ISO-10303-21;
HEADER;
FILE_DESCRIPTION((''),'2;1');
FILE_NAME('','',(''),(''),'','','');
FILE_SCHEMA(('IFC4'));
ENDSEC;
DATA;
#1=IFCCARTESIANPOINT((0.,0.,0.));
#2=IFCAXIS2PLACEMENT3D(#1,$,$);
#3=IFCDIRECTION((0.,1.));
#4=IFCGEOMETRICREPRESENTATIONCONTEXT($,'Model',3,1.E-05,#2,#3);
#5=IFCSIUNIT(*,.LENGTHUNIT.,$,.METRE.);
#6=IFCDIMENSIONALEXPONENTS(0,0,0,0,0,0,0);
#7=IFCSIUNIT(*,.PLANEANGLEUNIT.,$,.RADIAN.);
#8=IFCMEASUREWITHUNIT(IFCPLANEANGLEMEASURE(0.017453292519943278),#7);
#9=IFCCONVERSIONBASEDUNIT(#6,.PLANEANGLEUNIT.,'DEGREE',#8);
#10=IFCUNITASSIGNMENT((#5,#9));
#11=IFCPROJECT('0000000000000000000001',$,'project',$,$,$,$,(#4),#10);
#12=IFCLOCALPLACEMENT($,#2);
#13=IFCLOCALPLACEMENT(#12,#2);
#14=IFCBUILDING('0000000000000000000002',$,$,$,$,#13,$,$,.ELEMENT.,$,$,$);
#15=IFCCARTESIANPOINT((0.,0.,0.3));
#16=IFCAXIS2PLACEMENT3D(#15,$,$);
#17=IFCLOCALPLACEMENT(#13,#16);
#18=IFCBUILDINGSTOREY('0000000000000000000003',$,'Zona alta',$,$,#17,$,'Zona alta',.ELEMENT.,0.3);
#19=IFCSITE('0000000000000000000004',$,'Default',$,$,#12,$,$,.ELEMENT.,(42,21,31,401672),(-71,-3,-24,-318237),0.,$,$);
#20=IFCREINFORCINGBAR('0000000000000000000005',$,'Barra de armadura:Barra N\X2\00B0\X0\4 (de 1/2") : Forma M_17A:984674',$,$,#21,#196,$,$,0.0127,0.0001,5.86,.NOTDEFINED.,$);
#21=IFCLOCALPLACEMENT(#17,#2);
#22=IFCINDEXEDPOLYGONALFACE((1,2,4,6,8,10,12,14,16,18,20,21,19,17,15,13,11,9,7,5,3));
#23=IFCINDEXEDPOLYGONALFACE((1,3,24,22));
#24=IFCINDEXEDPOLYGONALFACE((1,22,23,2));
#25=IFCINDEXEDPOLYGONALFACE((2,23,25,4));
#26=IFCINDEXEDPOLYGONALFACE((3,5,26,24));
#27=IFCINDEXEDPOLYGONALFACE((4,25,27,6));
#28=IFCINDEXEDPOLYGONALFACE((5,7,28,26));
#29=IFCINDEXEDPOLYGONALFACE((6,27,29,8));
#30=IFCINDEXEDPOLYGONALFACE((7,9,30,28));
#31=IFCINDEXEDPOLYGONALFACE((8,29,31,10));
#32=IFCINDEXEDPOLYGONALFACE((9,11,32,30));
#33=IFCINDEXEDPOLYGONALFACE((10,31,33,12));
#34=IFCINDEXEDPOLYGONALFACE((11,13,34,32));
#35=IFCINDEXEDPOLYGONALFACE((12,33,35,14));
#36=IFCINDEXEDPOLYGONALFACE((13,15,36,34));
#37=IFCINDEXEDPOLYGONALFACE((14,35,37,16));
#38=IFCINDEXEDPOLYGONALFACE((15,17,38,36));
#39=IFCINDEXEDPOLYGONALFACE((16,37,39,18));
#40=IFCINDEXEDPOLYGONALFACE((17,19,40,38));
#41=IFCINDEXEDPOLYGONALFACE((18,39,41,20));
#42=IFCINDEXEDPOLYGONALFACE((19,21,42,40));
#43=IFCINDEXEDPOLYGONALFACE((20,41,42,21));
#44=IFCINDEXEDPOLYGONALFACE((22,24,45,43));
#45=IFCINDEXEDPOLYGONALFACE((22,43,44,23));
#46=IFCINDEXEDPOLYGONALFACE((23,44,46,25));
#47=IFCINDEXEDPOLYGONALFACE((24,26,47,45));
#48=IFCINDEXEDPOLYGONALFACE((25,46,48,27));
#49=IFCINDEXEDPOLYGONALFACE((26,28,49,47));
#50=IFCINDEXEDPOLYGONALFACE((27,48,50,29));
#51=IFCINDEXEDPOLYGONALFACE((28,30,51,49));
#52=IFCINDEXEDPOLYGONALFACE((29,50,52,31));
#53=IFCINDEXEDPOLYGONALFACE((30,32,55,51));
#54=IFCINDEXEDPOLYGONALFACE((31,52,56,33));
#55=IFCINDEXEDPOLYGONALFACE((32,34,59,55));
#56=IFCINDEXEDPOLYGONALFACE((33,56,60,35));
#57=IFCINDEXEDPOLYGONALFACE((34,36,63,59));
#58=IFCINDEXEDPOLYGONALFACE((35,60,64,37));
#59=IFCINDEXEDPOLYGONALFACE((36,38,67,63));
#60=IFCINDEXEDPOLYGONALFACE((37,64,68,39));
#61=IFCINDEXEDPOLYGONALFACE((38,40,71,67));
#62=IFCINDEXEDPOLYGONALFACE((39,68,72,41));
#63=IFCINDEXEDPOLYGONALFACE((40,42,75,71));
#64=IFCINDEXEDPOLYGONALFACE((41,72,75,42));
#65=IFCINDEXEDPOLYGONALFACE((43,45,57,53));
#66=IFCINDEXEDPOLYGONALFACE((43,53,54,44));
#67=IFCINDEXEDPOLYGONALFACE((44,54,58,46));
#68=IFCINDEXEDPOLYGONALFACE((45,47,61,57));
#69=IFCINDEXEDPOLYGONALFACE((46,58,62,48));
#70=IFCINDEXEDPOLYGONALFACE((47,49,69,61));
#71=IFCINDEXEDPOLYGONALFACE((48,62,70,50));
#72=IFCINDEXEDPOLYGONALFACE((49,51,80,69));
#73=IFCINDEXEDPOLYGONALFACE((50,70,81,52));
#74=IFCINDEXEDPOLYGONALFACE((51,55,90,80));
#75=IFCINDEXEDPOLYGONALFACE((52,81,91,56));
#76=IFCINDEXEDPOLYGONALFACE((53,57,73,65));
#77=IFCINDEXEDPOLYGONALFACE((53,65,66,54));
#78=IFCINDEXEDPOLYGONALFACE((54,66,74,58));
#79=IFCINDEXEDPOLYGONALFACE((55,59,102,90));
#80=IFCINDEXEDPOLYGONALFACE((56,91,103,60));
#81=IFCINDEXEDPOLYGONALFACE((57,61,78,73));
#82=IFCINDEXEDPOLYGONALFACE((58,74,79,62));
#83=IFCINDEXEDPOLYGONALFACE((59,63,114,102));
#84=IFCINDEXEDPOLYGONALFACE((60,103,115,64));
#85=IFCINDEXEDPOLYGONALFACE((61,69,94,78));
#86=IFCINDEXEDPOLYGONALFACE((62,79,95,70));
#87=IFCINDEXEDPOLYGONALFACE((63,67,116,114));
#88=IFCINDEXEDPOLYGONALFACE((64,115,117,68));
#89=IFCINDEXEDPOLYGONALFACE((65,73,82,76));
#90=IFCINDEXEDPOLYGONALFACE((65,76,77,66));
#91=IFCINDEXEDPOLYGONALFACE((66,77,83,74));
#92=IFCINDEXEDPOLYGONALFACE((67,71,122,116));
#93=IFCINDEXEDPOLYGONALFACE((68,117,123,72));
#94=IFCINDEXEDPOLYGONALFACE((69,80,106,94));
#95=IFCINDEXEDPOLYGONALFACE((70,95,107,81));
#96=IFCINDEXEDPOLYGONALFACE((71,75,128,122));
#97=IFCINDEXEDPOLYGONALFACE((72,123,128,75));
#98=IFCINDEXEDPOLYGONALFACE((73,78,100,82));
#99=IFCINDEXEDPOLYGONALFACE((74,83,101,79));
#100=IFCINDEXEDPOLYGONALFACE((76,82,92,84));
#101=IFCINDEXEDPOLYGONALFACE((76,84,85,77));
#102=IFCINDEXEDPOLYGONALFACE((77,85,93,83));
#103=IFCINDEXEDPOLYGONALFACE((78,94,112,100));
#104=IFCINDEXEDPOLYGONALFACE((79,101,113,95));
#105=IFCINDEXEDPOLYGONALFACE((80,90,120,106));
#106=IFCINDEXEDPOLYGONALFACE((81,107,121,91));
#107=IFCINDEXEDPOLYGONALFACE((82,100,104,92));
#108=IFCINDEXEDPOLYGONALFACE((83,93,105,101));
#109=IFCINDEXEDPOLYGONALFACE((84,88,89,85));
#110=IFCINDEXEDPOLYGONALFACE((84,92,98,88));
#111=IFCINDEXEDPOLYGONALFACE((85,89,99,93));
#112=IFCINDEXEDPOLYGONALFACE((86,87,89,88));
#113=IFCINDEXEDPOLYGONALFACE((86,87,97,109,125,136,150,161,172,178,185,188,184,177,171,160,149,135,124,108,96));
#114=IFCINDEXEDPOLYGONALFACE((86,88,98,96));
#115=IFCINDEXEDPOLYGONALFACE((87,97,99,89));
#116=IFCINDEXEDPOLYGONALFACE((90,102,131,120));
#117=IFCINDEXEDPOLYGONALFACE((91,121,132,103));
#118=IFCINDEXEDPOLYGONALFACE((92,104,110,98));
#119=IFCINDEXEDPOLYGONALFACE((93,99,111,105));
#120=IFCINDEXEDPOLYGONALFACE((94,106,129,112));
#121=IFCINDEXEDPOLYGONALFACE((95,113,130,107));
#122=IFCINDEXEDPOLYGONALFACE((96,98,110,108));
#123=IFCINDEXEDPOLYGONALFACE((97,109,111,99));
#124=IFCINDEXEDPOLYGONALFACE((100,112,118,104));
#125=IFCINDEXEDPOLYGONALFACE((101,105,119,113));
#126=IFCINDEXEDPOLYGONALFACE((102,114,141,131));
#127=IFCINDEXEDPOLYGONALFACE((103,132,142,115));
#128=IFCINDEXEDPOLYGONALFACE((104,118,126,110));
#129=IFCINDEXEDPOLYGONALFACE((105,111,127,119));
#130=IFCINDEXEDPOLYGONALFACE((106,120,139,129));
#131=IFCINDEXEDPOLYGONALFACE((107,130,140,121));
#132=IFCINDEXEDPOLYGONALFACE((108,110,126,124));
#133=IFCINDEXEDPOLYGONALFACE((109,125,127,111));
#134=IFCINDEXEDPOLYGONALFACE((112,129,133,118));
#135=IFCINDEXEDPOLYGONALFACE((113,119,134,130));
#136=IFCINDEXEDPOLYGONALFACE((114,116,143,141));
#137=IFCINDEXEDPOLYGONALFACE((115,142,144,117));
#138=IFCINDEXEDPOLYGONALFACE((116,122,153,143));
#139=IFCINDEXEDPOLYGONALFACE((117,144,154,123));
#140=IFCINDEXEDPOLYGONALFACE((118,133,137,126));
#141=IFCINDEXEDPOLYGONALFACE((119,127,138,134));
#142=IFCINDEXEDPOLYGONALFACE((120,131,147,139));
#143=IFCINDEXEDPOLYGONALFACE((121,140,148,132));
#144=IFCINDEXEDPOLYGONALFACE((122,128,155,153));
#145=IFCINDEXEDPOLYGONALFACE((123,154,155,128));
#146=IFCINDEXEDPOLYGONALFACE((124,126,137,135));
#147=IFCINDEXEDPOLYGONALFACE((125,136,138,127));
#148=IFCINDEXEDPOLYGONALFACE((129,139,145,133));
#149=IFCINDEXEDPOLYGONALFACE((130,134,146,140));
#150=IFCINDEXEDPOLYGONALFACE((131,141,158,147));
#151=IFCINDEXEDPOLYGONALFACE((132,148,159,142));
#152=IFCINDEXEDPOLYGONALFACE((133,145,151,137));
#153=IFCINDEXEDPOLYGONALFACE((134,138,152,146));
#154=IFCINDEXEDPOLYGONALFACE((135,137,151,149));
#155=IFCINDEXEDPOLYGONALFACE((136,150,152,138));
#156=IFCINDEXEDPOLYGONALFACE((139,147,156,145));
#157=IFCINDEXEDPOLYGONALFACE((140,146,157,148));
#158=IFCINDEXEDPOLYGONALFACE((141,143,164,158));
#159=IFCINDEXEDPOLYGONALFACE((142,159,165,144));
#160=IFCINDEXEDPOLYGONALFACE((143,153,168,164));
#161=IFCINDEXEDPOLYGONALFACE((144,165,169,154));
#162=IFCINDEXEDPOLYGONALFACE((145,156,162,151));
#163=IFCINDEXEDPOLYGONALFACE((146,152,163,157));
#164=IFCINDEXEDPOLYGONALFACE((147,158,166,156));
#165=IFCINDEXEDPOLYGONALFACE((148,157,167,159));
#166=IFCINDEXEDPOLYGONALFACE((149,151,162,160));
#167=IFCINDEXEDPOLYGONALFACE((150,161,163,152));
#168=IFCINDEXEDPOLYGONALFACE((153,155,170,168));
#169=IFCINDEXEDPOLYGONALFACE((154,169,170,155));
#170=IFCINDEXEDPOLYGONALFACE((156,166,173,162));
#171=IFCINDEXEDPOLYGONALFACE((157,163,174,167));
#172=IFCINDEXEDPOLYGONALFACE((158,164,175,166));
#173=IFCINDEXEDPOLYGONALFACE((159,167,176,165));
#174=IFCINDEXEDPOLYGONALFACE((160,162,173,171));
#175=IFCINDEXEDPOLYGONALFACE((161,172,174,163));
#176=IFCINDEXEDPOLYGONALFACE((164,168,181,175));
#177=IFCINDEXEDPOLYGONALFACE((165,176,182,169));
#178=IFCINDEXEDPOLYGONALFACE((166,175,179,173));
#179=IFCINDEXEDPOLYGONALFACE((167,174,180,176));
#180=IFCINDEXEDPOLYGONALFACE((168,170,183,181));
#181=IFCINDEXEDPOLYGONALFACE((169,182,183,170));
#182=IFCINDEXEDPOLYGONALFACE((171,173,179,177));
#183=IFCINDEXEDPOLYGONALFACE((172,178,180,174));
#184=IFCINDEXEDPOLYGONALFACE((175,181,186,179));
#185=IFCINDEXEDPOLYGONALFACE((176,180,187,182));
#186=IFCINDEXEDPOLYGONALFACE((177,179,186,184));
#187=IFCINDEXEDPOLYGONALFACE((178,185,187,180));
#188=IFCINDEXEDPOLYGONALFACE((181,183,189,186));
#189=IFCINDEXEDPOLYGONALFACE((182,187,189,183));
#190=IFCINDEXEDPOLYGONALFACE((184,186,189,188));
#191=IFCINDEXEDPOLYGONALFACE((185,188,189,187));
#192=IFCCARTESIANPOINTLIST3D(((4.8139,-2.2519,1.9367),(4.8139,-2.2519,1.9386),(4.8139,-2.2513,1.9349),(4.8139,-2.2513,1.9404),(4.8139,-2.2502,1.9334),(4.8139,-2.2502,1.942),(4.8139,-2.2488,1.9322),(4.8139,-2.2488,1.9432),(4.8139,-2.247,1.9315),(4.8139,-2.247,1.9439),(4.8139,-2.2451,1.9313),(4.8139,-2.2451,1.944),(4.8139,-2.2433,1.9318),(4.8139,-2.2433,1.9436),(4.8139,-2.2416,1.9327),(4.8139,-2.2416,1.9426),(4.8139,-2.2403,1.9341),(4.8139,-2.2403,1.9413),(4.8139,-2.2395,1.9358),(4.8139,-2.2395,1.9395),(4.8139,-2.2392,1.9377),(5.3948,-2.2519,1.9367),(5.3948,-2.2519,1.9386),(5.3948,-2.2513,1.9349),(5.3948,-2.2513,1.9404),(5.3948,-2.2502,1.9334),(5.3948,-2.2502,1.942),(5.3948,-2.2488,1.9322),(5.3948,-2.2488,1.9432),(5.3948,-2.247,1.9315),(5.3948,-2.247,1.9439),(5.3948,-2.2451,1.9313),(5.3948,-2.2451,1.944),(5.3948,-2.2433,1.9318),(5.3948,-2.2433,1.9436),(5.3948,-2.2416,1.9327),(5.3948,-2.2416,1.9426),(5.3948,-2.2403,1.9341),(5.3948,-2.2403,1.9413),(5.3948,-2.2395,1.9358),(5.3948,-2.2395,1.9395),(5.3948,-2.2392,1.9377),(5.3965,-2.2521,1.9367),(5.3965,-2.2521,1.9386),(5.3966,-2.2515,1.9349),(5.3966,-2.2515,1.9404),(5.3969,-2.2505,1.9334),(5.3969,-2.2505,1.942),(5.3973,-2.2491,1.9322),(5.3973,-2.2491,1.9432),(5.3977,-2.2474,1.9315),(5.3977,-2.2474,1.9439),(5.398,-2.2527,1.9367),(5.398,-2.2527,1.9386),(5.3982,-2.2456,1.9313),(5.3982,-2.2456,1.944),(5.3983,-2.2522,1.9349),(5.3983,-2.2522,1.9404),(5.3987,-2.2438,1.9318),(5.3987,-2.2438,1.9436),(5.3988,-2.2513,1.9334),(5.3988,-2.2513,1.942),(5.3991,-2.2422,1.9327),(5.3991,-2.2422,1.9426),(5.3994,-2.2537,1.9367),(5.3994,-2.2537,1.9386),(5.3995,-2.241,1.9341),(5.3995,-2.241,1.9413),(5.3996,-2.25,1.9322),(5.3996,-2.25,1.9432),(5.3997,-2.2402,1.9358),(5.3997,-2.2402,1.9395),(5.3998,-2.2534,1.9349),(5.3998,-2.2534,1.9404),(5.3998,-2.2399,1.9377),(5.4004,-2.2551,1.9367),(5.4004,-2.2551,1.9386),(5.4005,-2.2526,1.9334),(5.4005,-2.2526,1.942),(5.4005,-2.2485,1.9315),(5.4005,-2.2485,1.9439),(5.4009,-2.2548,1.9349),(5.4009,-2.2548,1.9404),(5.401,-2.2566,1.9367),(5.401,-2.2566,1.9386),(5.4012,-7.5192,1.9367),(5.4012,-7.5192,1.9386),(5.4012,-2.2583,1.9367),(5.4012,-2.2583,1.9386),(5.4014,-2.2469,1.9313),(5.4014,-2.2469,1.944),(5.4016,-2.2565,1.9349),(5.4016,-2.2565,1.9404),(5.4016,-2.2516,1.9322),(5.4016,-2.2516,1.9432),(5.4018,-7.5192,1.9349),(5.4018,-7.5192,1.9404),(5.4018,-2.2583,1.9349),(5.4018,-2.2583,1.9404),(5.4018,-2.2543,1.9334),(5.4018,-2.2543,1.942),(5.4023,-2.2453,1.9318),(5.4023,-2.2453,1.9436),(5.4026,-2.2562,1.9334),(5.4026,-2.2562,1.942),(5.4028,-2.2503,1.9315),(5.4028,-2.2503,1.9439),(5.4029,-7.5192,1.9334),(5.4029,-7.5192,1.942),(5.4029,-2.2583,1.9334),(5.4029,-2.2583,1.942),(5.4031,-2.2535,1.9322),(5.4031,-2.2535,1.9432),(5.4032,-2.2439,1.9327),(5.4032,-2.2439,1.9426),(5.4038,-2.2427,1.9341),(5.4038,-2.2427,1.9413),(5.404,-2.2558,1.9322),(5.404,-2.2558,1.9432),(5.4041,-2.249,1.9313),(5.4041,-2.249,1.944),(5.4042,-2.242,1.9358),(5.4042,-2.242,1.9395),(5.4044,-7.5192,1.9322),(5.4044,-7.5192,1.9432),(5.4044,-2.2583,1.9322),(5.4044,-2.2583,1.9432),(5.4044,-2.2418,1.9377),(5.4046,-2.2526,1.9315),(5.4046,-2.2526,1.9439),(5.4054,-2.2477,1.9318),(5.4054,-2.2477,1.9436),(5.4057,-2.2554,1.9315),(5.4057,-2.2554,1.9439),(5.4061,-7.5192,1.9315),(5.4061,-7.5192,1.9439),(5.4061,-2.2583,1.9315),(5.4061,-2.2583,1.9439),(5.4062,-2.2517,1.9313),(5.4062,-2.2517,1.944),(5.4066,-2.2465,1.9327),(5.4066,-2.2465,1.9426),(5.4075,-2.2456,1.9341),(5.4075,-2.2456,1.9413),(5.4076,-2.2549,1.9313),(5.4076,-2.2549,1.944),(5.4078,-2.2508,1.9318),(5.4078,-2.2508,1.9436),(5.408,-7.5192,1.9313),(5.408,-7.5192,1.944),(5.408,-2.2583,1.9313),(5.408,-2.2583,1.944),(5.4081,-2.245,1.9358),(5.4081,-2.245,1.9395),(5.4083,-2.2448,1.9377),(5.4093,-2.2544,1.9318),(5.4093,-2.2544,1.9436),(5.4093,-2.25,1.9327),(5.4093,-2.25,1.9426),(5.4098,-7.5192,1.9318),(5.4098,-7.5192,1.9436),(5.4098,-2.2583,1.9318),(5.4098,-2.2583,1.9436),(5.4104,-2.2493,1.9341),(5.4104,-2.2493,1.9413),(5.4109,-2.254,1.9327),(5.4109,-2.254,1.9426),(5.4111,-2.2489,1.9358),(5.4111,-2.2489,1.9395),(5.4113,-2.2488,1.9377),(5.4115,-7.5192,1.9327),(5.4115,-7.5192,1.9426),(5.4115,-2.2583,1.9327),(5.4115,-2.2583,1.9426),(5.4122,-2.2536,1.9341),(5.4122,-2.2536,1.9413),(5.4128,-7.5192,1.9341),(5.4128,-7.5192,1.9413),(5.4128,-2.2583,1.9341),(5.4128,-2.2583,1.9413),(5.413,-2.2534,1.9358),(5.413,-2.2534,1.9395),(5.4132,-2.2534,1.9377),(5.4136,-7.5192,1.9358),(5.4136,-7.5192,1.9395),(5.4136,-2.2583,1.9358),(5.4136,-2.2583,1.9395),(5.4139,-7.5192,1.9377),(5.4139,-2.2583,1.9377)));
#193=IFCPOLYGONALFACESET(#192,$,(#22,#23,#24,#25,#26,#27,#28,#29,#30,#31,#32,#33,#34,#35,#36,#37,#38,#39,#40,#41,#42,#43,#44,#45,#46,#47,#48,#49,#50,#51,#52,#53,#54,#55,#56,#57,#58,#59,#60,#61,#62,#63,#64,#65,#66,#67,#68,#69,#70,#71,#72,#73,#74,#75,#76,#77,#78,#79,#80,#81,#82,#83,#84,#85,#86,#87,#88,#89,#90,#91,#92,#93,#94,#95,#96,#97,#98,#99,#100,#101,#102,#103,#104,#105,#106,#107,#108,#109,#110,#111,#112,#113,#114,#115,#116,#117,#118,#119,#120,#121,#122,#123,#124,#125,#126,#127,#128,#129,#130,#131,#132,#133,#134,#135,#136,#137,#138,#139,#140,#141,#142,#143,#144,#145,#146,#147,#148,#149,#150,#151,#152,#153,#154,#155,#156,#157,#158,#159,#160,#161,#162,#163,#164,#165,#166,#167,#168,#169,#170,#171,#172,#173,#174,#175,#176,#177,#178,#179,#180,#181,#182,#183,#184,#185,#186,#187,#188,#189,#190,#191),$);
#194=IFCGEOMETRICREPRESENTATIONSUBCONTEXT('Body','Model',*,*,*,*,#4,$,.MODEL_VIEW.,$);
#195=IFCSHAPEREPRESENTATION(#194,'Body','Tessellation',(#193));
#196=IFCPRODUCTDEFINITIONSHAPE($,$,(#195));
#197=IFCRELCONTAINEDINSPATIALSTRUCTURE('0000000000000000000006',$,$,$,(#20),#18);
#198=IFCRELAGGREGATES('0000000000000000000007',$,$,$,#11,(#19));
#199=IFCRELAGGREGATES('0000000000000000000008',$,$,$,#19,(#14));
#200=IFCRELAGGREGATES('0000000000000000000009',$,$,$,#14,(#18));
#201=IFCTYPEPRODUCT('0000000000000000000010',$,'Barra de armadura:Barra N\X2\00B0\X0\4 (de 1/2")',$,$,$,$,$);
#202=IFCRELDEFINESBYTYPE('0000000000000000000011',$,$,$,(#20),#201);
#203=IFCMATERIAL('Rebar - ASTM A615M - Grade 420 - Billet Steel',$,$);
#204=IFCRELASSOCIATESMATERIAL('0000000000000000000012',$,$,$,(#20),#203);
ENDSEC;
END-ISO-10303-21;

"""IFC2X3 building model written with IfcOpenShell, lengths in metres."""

from ifc_helpers import new_model, entity, si_unit, converted_unit, direction, frame, origin, place, context, subcontext, project, spatial, material, type_object, element, save


model = new_model("IFC2X3")

# Units and contexts
model_context = context("Model", 3, precision=1e-05, world=origin(), true_north=direction((0.0, 1.0)))
body_context = subcontext(model_context, "Body", "Model", "MODEL_VIEW")
ifc_project = project(units=[si_unit("LENGTHUNIT", "METRE"), converted_unit("PLANEANGLEUNIT", "DEGREE", entity("IfcPlaneAngleMeasure", 0.017453292519943278), si_unit("PLANEANGLEUNIT", "RADIAN"), dimensions=[0, 0, 0, 0, 0, 0, 0])], contexts=[model_context])

# Site, building, storey
site_placement = place(None, origin())
site = spatial("IfcSite", under=ifc_project, at=site_placement, Name="Default", CompositionType="ELEMENT", RefLatitude=(42, 21, 31, 401672), RefLongitude=(-71, -3, -24, -318237), RefElevation=0.0)
building_placement = place(site_placement, origin())
building = spatial("IfcBuilding", under=site, at=building_placement, CompositionType="ELEMENT")
storey_placement = place(building_placement, frame((0.0, 0.0, 0.3)))
storey = spatial("IfcBuildingStorey", under=building, at=storey_placement, Name="Zona alta", LongName="Zona alta", CompositionType="ELEMENT", Elevation=0.3)

# Reinforcing bar
ifc_material_1 = material(Name="Rebar - ASTM A615M - Grade 420 - Billet Steel")
type_product_1 = type_object("IfcTypeProduct", Name="Barra de armadura:Barra N°4 (de 1/2\")")
reinforcing_bar_1_placement = place(storey_placement, origin())
element("IfcReinforcingBar", 1, at=reinforcing_bar_1_placement, inside=storey, type_object=type_product_1, material=ifc_material_1, Name="Barra de armadura:Barra N°4 (de 1/2\") : Forma M_17A:984674", BarLength=5.86, BarRole="NOTDEFINED", CrossSectionArea=0.0001, NominalDiameter=0.0127, context=body_context, shape_type="AdvancedSweptSolid", body=[
    entity("IfcSweptDiskSolid", entity("IfcCompositeCurve", [entity("IfcCompositeCurveSegment", "CONTINUOUS", True, entity("IfcPolyline", [entity("IfcCartesianPoint", [5.4075, -7.5192, 1.9377]), entity("IfcCartesianPoint", [5.4075, -2.2583, 1.9377])])), entity("IfcCompositeCurveSegment", "CONTINUOUS", True, entity("IfcTrimmedCurve", entity("IfcCircle", entity("IfcAxis2Placement3D", entity("IfcCartesianPoint", [5.3948, -2.2583, 1.9377]), entity("IfcDirection", [0.0, 0.0, 1.0]), entity("IfcDirection", [0.0, 1.0, 0.0])), 0.0127), [entity("IfcParameterValue", 270.0)], [entity("IfcParameterValue", 360.0)], True, "PARAMETER")), entity("IfcCompositeCurveSegment", "CONTINUOUS", True, entity("IfcPolyline", [entity("IfcCartesianPoint", [5.3948, -2.2456, 1.9377]), entity("IfcCartesianPoint", [4.8139, -2.2456, 1.9377])]))], False), 0.0063, None, 0.0, 92.0),
])

save(model, "model.ifc")
